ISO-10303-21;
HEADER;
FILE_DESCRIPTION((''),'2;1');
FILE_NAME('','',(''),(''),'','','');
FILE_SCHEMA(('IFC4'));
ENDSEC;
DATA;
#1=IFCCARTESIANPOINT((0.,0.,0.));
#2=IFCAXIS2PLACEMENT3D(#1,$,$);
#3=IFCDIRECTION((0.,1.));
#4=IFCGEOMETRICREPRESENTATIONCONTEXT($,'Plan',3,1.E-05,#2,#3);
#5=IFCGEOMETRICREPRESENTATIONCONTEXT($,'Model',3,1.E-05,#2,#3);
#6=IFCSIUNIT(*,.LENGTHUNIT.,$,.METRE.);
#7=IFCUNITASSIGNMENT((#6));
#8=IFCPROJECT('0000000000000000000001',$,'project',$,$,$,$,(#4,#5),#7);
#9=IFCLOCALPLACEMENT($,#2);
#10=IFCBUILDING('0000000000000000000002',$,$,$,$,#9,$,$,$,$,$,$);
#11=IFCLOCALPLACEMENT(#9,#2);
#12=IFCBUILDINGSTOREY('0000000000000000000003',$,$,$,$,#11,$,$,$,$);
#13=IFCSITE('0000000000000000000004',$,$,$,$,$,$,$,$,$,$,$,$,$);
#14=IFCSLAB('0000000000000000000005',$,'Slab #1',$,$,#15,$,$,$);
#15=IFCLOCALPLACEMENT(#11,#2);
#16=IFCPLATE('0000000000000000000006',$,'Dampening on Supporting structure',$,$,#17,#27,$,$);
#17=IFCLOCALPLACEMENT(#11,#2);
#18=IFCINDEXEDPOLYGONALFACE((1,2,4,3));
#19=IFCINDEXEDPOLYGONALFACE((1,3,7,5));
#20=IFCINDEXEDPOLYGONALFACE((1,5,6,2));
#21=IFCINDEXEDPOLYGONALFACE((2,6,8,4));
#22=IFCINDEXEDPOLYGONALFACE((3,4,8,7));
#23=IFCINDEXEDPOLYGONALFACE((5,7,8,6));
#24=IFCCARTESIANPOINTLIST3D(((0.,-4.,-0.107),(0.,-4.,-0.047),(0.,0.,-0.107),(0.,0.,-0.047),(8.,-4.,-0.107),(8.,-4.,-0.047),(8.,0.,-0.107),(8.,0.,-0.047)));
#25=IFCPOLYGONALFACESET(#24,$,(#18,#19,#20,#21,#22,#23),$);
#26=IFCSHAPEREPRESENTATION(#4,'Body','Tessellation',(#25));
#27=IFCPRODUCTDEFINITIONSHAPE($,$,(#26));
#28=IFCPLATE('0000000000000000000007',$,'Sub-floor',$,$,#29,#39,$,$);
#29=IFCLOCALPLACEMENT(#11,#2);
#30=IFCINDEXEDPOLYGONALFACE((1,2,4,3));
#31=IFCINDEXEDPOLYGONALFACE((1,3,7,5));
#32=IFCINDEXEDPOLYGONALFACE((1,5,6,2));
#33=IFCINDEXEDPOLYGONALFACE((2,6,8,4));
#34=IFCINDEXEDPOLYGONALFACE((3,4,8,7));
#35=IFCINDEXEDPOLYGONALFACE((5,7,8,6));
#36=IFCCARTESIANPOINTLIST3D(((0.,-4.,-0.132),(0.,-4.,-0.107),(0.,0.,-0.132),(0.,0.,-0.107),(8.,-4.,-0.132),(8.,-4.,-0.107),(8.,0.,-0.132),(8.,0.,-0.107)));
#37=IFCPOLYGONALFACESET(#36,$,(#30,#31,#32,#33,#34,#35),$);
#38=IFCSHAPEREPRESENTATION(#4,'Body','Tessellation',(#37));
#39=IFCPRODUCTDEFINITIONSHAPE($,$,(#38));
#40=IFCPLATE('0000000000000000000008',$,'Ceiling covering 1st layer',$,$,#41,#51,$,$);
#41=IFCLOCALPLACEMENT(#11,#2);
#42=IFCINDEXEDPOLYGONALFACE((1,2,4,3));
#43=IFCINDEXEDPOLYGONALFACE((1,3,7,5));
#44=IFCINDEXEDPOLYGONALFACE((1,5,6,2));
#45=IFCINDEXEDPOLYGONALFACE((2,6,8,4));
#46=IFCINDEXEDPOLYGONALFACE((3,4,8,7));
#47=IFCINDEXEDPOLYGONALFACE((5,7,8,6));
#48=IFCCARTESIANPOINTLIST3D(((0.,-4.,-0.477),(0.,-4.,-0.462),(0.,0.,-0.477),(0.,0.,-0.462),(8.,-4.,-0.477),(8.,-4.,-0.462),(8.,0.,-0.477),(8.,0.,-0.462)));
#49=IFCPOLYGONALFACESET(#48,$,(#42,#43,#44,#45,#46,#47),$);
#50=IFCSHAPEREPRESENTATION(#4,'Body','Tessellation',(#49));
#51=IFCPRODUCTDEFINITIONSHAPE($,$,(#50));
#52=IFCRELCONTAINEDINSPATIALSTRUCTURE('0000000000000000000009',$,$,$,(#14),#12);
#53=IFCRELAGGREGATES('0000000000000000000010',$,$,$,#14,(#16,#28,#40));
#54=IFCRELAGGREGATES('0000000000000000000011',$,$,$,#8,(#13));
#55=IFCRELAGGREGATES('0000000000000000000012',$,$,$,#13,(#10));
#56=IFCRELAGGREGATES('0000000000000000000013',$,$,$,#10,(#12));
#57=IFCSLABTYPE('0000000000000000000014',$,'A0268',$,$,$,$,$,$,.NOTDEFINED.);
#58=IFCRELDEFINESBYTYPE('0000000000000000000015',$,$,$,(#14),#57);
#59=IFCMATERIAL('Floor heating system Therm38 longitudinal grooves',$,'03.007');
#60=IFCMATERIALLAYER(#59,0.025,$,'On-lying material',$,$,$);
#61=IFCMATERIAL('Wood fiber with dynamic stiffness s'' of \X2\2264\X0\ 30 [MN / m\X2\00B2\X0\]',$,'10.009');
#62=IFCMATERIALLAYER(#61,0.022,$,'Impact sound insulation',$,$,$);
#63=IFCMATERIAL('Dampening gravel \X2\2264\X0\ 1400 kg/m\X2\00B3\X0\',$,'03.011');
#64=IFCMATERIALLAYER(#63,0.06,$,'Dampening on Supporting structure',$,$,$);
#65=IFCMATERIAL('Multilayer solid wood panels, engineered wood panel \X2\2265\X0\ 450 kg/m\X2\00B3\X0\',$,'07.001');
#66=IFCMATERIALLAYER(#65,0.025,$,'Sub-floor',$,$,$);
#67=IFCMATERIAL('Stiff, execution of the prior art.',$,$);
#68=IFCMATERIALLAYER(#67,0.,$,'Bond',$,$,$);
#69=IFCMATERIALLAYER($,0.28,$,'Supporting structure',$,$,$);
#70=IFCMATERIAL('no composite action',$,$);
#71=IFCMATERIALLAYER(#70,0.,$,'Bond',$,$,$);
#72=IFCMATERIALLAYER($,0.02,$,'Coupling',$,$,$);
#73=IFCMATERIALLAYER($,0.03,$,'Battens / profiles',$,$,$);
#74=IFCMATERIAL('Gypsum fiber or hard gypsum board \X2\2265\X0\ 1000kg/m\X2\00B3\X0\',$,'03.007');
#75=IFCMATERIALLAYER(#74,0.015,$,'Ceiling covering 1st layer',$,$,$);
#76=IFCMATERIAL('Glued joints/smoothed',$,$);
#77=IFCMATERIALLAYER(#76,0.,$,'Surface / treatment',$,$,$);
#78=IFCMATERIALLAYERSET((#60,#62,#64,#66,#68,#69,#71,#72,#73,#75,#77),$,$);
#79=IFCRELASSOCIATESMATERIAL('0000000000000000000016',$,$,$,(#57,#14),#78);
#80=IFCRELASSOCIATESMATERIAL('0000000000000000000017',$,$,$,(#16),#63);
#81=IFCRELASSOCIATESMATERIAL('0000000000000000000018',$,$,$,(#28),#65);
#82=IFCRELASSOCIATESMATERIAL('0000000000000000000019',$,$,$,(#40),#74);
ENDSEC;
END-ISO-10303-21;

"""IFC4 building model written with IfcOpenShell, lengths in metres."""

from ifc_helpers import new_model, si_unit, direction, frame, frame_2d, origin, place, context, project, spatial, rectangle, extrude, material, layer, layer_set, type_object, element, aggregate, save


model = new_model("IFC4")

# Units and contexts
plan_context = context("Plan", 3, precision=1e-05, world=origin(), true_north=direction((0.0, 1.0)))
model_context = context("Model", 3, precision=1e-05, world=origin(), true_north=direction((0.0, 1.0)))
ifc_project = project(units=[si_unit("LENGTHUNIT", "METRE")], contexts=[plan_context, model_context])

# Site, building, storey
site = spatial("IfcSite", under=ifc_project)
building_placement = place(None, origin())
building = spatial("IfcBuilding", under=site, at=building_placement)
storey_placement = place(building_placement, origin())
storey = spatial("IfcBuildingStorey", under=building, at=storey_placement)

# Slab, plates
ifc_material_1 = material(Name="Floor heating system Therm38 longitudinal grooves", Category="03.007")
ifc_layer_1 = layer(ifc_material_1, 0.025, Name="On-lying material")
ifc_material_2 = material(Name="Wood fiber with dynamic stiffness s' of ≤ 30 [MN / m²]", Category="10.009")
ifc_layer_2 = layer(ifc_material_2, 0.022, Name="Impact sound insulation")
ifc_material_3 = material(Name="Dampening gravel ≤ 1400 kg/m³", Category="03.011")
ifc_layer_3 = layer(ifc_material_3, 0.06, Name="Dampening on Supporting structure")
ifc_material_4 = material(Name="Multilayer solid wood panels, engineered wood panel ≥ 450 kg/m³", Category="07.001")
ifc_layer_4 = layer(ifc_material_4, 0.025, Name="Sub-floor")
ifc_material_5 = material(Name="Stiff, execution of the prior art.")
ifc_layer_5 = layer(ifc_material_5, 0.0, Name="Bond")
ifc_layer_6 = layer(None, 0.28, Name="Supporting structure")
ifc_material_6 = material(Name="no composite action")
ifc_layer_7 = layer(ifc_material_6, 0.0, Name="Bond")
ifc_layer_8 = layer(None, 0.02, Name="Coupling")
ifc_layer_9 = layer(None, 0.03, Name="Battens / profiles")
ifc_material_7 = material(Name="Gypsum fiber or hard gypsum board ≥ 1000kg/m³", Category="03.007")
ifc_layer_10 = layer(ifc_material_7, 0.015, Name="Ceiling covering 1st layer")
ifc_material_8 = material(Name="Glued joints/smoothed")
ifc_layer_11 = layer(ifc_material_8, 0.0, Name="Surface / treatment")
ifc_layer_set = layer_set([ifc_layer_1, ifc_layer_2, ifc_layer_3, ifc_layer_4, ifc_layer_5, ifc_layer_6, ifc_layer_7, ifc_layer_8, ifc_layer_9, ifc_layer_10, ifc_layer_11])
slab_type = type_object("IfcSlabType", Name="A0268", PredefinedType="NOTDEFINED", material=ifc_layer_set)
slab_placement = place(None, frame((0.0, 0.0, 0.0), z_axis=(0.0, 0.0, -1.0), x_axis=(1.0, 0.0, 0.0)))
slab = element("IfcSlab", 1, at=slab_placement, inside=storey, type_object=slab_type, material=ifc_layer_set, Name="Slab #1")
plate_1_placement = place(slab_placement, origin())
plate_1 = element("IfcPlate", 2, at=plate_1_placement, material=ifc_material_3, Name="Dampening on Supporting structure", context=plan_context, shape_type="SweptSolid", body=[
    extrude(rectangle(XDim=8.0, YDim=4.0, at=frame_2d((4.0, 2.0), x_axis=(1.0, 0.0))), frame((0.0, 0.0, 0.047), z_axis=(0.0, 0.0, 1.0), x_axis=(1.0, 0.0, 0.0)), (0.0, 0.0, 1.0), 0.06),
])
plate_2_placement = place(slab_placement, origin())
plate_2 = element("IfcPlate", 3, at=plate_2_placement, material=ifc_material_4, Name="Sub-floor", context=plan_context, shape_type="SweptSolid", body=[
    extrude(rectangle(XDim=8.0, YDim=4.0, at=frame_2d((4.0, 2.0), x_axis=(1.0, 0.0))), frame((0.0, 0.0, 0.107), z_axis=(0.0, 0.0, 1.0), x_axis=(1.0, 0.0, 0.0)), (0.0, 0.0, 1.0), 0.025),
])
plate_3_placement = place(slab_placement, origin())
plate_3 = element("IfcPlate", 4, at=plate_3_placement, material=ifc_material_7, Name="Ceiling covering 1st layer", context=plan_context, shape_type="SweptSolid", body=[
    extrude(rectangle(XDim=8.0, YDim=4.0, at=frame_2d((4.0, 2.0), x_axis=(1.0, 0.0))), frame((0.0, 0.0, 0.462), z_axis=(0.0, 0.0, 1.0), x_axis=(1.0, 0.0, 0.0)), (0.0, 0.0, 1.0), 0.015),
])
aggregate(slab, [plate_1, plate_2, plate_3])

save(model, "model.ifc")
